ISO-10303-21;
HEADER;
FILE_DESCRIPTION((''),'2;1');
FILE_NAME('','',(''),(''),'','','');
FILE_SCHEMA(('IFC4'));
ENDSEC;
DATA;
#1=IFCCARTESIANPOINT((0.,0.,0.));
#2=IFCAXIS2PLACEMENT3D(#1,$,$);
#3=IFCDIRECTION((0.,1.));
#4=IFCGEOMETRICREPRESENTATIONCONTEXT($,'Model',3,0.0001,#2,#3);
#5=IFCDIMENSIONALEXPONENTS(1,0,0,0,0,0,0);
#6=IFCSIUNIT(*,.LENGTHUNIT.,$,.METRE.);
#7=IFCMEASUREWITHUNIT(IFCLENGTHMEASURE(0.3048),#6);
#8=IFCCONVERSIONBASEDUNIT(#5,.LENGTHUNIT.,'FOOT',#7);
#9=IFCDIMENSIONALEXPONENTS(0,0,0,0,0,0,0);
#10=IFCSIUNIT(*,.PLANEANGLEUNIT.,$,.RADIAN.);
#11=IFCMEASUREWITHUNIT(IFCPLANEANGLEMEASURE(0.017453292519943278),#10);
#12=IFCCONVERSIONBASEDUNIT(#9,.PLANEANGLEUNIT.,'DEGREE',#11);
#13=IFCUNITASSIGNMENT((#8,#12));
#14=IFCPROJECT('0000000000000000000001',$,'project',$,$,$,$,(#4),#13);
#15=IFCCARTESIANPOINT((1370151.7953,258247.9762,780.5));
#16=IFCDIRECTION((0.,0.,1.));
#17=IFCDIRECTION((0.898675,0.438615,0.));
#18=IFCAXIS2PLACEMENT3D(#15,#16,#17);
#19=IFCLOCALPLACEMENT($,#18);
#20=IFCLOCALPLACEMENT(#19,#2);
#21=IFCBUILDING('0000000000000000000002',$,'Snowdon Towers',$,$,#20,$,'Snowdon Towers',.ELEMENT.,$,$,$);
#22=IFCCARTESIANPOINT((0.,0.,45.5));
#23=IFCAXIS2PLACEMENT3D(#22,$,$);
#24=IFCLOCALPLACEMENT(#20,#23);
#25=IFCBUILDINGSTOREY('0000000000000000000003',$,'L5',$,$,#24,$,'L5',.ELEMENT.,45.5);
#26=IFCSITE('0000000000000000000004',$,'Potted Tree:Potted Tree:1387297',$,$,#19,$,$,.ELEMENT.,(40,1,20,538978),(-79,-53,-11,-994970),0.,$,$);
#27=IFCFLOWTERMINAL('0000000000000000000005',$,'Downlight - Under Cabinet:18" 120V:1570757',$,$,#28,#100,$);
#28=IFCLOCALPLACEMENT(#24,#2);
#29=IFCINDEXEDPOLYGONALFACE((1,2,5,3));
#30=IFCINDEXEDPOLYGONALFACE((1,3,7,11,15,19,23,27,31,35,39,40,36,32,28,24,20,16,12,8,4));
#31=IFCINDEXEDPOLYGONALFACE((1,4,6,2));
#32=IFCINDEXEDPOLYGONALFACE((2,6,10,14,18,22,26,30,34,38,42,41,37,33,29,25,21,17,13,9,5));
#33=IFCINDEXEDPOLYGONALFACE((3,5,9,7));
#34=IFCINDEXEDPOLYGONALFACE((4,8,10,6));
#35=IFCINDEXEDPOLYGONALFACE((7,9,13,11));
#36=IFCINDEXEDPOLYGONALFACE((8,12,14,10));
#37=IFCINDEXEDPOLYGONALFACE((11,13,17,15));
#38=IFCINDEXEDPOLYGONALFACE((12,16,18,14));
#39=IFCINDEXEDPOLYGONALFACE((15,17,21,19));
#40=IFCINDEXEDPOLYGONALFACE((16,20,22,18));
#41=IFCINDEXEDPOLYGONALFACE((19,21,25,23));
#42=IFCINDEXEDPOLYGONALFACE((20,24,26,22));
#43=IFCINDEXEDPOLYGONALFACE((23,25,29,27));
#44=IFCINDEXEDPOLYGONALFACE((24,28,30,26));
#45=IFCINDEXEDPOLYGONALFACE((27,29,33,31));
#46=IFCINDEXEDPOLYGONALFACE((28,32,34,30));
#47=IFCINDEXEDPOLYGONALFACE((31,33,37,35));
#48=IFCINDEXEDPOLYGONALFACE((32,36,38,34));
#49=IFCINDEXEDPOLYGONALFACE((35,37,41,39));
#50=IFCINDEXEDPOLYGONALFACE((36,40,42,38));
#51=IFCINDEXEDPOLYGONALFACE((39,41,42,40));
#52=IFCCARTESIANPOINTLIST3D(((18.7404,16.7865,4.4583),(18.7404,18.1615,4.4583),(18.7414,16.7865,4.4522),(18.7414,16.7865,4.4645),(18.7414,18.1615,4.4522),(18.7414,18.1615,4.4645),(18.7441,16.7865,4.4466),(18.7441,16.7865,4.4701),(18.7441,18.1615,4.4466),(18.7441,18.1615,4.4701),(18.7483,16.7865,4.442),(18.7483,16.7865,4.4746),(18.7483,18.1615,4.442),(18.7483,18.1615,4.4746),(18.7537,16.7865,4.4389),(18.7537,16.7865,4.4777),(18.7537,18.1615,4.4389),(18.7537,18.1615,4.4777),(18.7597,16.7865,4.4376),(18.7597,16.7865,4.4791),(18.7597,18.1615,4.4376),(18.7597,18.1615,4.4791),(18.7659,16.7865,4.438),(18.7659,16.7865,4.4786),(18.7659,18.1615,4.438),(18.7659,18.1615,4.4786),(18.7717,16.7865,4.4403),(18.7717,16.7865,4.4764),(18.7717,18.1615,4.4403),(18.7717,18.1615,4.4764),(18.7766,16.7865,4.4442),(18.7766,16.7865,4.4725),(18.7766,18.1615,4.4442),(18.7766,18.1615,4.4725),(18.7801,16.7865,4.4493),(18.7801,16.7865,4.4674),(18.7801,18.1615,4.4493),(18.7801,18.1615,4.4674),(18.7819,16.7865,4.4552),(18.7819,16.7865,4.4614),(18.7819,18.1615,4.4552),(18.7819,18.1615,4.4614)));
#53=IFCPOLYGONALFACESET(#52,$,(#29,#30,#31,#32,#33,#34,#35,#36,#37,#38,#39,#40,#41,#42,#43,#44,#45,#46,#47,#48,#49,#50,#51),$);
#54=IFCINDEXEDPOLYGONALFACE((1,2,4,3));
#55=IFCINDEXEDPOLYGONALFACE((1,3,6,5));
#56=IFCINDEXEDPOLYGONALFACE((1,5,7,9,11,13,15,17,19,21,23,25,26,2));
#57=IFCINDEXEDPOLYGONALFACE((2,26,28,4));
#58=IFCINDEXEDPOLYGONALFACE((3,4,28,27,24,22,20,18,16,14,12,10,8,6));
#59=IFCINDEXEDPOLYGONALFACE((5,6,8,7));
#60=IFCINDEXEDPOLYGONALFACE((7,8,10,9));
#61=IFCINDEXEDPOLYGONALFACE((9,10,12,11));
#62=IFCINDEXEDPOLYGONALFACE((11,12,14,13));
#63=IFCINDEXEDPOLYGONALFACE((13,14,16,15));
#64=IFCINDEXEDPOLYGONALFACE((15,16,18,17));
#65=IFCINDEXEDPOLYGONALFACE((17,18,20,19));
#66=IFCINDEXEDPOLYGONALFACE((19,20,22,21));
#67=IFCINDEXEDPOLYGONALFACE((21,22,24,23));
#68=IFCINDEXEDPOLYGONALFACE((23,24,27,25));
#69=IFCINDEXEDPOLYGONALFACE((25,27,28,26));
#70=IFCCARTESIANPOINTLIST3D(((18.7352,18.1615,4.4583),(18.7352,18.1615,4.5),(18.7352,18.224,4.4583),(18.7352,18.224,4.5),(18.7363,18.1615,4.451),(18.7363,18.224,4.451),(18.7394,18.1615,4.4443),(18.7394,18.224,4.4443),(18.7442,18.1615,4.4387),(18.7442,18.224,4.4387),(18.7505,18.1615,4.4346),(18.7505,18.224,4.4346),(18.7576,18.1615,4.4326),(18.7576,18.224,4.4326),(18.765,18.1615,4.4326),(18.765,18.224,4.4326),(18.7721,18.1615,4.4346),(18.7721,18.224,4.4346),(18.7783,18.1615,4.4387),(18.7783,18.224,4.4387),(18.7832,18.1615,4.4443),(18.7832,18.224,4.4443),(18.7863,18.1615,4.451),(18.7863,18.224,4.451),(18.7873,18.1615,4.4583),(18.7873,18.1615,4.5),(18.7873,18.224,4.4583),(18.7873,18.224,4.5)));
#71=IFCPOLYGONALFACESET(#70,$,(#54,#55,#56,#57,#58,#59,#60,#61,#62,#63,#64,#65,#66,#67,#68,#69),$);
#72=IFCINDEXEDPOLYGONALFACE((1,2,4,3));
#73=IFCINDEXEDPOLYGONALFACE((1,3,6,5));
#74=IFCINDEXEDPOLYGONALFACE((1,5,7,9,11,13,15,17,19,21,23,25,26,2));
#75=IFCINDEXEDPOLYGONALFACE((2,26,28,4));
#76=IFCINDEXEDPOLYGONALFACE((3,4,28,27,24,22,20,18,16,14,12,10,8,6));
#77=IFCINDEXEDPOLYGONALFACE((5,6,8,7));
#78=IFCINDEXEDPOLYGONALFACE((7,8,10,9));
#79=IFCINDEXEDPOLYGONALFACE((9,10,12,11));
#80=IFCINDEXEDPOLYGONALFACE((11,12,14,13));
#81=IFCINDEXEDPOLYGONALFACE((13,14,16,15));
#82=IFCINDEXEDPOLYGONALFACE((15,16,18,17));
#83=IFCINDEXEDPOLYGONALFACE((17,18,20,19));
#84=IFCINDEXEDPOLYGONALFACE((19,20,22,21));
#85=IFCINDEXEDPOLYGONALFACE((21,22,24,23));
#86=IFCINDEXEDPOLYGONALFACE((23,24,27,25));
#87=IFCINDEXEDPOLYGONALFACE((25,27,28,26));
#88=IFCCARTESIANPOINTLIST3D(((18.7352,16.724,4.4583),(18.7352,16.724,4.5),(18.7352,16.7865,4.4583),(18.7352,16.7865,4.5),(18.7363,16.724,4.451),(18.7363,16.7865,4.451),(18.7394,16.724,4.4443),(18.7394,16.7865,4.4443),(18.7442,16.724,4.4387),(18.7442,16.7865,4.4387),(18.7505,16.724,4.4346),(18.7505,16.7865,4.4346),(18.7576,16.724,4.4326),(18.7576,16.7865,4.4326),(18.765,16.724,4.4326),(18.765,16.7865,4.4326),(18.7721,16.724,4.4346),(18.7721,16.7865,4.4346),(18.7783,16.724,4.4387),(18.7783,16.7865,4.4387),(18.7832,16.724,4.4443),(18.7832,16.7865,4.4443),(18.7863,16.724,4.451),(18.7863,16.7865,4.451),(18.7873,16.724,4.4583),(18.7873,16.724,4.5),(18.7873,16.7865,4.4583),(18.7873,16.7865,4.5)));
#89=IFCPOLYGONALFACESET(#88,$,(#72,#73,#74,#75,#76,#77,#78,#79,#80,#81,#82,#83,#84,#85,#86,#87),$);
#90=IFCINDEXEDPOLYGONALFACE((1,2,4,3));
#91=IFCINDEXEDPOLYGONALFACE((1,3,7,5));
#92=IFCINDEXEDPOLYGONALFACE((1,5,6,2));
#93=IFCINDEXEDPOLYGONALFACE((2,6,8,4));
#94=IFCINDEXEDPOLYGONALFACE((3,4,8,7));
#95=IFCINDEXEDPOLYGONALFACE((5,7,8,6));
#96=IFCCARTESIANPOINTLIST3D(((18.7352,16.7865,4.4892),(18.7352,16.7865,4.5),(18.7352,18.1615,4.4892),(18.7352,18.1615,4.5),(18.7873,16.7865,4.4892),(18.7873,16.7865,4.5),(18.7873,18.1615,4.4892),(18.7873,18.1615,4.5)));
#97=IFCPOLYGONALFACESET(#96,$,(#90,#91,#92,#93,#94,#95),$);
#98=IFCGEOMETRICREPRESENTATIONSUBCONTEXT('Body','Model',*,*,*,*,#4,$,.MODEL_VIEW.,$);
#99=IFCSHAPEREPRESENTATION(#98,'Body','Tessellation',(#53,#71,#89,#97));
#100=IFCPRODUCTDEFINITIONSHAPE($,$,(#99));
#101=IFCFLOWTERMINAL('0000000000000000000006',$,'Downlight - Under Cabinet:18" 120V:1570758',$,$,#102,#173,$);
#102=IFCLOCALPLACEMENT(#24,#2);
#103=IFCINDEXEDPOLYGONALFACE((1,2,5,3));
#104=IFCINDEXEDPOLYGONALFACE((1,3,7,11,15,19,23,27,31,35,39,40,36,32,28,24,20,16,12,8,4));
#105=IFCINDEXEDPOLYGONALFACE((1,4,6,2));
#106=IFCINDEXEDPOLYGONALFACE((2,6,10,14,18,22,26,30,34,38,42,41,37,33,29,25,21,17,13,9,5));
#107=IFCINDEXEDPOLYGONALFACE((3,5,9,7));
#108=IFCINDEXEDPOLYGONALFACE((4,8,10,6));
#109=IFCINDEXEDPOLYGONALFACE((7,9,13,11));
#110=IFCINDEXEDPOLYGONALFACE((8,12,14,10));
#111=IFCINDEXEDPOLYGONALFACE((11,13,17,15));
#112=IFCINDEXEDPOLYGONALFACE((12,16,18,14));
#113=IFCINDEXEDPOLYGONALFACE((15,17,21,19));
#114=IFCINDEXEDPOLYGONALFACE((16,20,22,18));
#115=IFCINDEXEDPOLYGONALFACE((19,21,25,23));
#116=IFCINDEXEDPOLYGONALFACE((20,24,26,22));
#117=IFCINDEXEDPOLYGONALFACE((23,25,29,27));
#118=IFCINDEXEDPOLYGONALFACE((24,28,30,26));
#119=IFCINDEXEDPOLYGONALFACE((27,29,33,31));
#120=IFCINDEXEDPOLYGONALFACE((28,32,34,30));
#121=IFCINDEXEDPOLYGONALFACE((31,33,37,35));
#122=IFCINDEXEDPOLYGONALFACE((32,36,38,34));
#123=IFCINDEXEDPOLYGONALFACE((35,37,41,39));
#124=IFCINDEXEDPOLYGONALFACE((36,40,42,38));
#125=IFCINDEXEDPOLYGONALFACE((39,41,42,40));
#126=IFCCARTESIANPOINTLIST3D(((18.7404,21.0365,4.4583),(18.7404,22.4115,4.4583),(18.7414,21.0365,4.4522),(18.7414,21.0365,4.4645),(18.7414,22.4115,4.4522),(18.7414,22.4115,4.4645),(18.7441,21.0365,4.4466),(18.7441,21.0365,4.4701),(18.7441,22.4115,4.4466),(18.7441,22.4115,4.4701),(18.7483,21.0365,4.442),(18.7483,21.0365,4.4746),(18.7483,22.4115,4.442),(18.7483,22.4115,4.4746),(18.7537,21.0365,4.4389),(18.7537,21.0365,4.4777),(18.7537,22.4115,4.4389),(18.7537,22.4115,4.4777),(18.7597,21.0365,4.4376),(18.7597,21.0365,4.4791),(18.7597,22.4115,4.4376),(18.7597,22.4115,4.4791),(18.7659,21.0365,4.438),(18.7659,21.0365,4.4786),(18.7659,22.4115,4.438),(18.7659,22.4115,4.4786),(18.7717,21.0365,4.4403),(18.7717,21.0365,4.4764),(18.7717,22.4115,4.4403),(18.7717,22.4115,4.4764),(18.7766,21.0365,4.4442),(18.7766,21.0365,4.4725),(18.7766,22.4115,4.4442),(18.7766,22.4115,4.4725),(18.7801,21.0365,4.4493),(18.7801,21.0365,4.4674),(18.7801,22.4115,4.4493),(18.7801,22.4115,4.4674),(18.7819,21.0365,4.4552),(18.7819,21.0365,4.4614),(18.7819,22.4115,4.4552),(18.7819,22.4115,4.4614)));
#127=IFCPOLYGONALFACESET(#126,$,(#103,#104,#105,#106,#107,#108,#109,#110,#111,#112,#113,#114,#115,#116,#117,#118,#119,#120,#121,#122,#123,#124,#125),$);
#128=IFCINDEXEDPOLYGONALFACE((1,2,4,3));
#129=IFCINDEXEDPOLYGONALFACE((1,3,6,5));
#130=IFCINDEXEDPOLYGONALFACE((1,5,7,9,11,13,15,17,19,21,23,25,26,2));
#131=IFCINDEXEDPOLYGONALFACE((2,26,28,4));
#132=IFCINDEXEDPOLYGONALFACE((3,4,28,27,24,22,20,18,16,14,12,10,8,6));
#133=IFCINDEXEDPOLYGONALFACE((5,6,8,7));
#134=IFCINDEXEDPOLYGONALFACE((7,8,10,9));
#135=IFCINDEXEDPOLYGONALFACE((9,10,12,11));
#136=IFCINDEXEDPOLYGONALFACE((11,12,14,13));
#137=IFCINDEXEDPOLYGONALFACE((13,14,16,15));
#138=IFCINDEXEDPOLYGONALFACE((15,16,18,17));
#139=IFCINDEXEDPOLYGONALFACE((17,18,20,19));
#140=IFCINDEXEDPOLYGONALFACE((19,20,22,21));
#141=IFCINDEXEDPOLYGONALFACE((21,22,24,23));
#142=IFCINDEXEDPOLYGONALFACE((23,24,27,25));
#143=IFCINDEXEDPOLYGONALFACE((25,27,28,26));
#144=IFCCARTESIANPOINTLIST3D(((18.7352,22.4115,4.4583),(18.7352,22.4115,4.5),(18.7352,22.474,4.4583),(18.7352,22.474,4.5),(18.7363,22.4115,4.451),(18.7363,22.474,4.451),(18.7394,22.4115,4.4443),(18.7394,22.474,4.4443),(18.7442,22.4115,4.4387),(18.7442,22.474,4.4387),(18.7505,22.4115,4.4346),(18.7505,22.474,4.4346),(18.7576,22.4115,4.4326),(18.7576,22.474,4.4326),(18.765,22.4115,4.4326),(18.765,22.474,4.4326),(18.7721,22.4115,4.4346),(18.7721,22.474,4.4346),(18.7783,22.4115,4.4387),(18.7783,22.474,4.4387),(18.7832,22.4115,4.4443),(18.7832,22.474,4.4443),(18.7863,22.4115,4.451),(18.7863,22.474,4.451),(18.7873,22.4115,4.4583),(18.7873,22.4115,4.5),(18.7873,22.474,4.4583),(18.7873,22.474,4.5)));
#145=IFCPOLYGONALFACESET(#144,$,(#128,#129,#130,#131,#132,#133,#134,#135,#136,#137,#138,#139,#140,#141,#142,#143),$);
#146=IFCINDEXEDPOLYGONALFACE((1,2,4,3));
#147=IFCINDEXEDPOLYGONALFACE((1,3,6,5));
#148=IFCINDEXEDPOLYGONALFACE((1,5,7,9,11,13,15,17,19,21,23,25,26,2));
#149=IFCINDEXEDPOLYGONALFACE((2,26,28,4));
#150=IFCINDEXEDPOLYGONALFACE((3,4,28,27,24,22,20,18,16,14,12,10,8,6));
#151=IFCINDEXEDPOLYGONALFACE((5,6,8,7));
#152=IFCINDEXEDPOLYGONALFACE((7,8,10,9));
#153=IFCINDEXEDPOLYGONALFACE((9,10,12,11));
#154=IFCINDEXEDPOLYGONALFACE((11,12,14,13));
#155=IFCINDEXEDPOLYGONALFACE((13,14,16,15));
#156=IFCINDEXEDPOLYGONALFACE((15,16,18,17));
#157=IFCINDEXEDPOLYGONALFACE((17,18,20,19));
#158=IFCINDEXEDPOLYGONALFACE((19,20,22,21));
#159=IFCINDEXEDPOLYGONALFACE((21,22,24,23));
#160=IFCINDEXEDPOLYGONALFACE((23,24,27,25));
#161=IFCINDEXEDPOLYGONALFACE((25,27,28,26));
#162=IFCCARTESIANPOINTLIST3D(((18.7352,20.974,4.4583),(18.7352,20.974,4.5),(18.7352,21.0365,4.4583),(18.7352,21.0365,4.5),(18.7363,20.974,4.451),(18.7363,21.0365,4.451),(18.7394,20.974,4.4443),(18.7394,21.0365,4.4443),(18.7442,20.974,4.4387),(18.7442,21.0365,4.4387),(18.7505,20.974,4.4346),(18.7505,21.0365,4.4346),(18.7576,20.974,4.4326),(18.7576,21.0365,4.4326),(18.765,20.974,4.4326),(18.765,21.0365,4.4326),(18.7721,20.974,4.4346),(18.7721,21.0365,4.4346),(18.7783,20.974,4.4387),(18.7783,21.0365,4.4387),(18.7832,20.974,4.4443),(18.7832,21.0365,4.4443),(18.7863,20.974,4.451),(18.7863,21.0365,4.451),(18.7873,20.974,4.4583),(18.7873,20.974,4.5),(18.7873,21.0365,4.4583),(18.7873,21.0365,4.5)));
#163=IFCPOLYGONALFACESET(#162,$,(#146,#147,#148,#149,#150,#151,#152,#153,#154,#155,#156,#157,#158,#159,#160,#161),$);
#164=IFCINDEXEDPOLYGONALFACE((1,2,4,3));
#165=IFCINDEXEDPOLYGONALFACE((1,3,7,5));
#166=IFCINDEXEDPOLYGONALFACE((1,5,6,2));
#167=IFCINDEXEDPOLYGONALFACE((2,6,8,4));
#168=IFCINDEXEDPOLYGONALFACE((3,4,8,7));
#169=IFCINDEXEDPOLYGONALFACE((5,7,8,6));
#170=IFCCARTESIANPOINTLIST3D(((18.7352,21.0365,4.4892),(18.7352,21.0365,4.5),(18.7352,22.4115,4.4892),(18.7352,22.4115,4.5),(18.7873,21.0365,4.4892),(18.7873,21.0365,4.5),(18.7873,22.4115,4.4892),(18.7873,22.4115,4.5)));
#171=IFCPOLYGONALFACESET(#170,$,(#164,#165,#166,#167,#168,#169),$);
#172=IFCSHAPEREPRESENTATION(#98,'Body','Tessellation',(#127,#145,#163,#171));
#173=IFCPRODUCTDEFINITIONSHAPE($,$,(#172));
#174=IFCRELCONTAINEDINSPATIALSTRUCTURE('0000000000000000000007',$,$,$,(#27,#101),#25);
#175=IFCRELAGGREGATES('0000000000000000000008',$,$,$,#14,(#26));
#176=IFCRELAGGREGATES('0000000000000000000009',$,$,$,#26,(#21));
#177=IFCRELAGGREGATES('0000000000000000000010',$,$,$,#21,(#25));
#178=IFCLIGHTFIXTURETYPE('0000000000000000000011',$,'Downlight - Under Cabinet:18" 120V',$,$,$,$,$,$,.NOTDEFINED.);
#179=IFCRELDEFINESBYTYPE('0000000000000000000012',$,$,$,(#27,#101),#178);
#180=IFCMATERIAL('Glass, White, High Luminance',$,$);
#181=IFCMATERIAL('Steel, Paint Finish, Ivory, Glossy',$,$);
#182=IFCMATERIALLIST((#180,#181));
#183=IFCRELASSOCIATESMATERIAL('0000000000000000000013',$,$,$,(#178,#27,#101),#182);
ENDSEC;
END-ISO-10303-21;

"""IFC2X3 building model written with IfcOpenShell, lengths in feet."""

from ifc_helpers import new_model, entity, si_unit, converted_unit, direction, frame, frame_2d, origin, origin_2d_with_axis, place, context, subcontext, project, spatial, polyline, circle_curve, parameter, trimmed, segment, composite_curve, rectangle, circle, outline, extrude, source, transform, mapped, material, material_list, type_object, type_shapes, element, save


model = new_model("IFC2X3")

# Units and contexts
model_context = context("Model", 3, precision=0.0001, world=origin(), true_north=direction((0.0, 1.0)))
body_context = subcontext(model_context, "Body", "Model", "MODEL_VIEW")
ifc_project = project(units=[converted_unit("LENGTHUNIT", "FOOT", entity("IfcLengthMeasure", 0.3048), si_unit("LENGTHUNIT", "METRE"), dimensions=[1, 0, 0, 0, 0, 0, 0]), converted_unit("PLANEANGLEUNIT", "DEGREE", entity("IfcPlaneAngleMeasure", 0.017453292519943278), si_unit("PLANEANGLEUNIT", "RADIAN"), dimensions=[0, 0, 0, 0, 0, 0, 0])], contexts=[model_context])

# Site, building, storey
site_placement = place(None, frame((1370151.7953, 258247.9762, 780.5), z_axis=(0.0, 0.0, 1.0), x_axis=(0.898675, 0.438615, 0.0)))
site = spatial("IfcSite", under=ifc_project, at=site_placement, Name="Potted Tree:Potted Tree:1387297", CompositionType="ELEMENT", RefLatitude=(40, 1, 20, 538978), RefLongitude=(-79, -53, -11, -994970), RefElevation=0.0)
building_placement = place(site_placement, origin())
building = spatial("IfcBuilding", under=site, at=building_placement, Name="Snowdon Towers", LongName="Snowdon Towers", CompositionType="ELEMENT")
storey_placement = place(building_placement, frame((0.0, 0.0, 45.5)))
storey = spatial("IfcBuildingStorey", under=building, at=storey_placement, Name="L5", LongName="L5", CompositionType="ELEMENT", Elevation=45.5)

# Flow terminals
ifc_material_1 = material(Name="Glass, White, High Luminance")
ifc_material_2 = material(Name="Steel, Paint Finish, Ivory, Glossy")
ifc_material_list_1 = material_list([ifc_material_1, ifc_material_2])
light_fixture_type_1 = type_object("IfcLightFixtureType", Name="Downlight - Under Cabinet:18\" 120V", PredefinedType="NOTDEFINED", material=ifc_material_list_1)
shared_shape_1 = source(origin(), body_context, "Body", "SweptSolid", [
    extrude(circle(Radius=0.0208, at=origin_2d_with_axis()), frame((-0.6875, 0.0, 4.4583), z_axis=(1.0, 0.0, 0.0), x_axis=(0.0, 1.0, 0.0)), (0.0, 0.0, 1.0), 1.375),
    extrude(outline(composite_curve([segment(polyline([(-0.0208, -0.026), (0.0208, -0.026)]), True, "CONTINUOUS"), segment(trimmed(circle_curve(frame_2d((0.0208, 0.0), x_axis=(0.0, 1.0)), 0.026), [parameter(180.0)], [parameter(0.0)], True, "PARAMETER"), True, "CONTINUOUS"), segment(polyline([(0.0208, 0.026), (-0.0208, 0.026)]), True, "CONTINUOUS"), segment(polyline([(-0.0208, 0.026), (-0.0208, -0.026)]), True, "CONTINUOUS")], self_intersect=False)), frame((0.6875, 0.0, 4.4792), z_axis=(1.0, 0.0, 0.0), x_axis=(0.0, 0.0, -1.0)), (0.0, 0.0, 1.0), 0.0625),
    extrude(outline(composite_curve([segment(polyline([(-0.026, -0.0208), (0.026, -0.0208)]), True, "CONTINUOUS"), segment(polyline([(0.026, -0.0208), (0.026, 0.0208)]), True, "CONTINUOUS"), segment(trimmed(circle_curve(frame_2d((0.0, 0.0208), x_axis=(0.0, -1.0)), 0.026), [parameter(90.0)], [parameter(270.0)], True, "PARAMETER"), True, "CONTINUOUS"), segment(polyline([(-0.026, 0.0208), (-0.026, -0.0208)]), True, "CONTINUOUS")], self_intersect=False)), frame((-0.75, 0.0, 4.4792), z_axis=(1.0, 0.0, 0.0), x_axis=(0.0, -1.0, 0.0)), (0.0, 0.0, 1.0), 0.0625),
    extrude(rectangle(XDim=1.375, YDim=0.0521, at=origin_2d_with_axis()), frame((0.0, 0.0, 4.4892), z_axis=(0.0, 0.0, 1.0), x_axis=(-1.0, 0.0, 0.0)), (0.0, 0.0, 1.0), 0.0108),
])
type_shapes(light_fixture_type_1, [shared_shape_1])
for number, where, z_axis, x_axis, name in (
    (1, (18.7613, 17.474, 0.0), (0.0, 0.0, 1.0), (0.0, 1.0, 0.0), "Downlight - Under Cabinet:18\" 120V:1570757"),
    (2, (18.7613, 21.724, 0.0), (0.0, 0.0, 1.0), (0.0, 1.0, 0.0), "Downlight - Under Cabinet:18\" 120V:1570758"),
):
    element("IfcFlowTerminal", number, at=place(storey_placement, frame(where, z_axis=z_axis, x_axis=x_axis)), inside=storey, type_object=light_fixture_type_1, material=ifc_material_list_1, Name=name, context=body_context, shape_type="MappedRepresentation", body=[
        mapped(shared_shape_1, transform((0.0, 0.0, 0.0), scale=1.0)),
    ])

save(model, "model.ifc")
